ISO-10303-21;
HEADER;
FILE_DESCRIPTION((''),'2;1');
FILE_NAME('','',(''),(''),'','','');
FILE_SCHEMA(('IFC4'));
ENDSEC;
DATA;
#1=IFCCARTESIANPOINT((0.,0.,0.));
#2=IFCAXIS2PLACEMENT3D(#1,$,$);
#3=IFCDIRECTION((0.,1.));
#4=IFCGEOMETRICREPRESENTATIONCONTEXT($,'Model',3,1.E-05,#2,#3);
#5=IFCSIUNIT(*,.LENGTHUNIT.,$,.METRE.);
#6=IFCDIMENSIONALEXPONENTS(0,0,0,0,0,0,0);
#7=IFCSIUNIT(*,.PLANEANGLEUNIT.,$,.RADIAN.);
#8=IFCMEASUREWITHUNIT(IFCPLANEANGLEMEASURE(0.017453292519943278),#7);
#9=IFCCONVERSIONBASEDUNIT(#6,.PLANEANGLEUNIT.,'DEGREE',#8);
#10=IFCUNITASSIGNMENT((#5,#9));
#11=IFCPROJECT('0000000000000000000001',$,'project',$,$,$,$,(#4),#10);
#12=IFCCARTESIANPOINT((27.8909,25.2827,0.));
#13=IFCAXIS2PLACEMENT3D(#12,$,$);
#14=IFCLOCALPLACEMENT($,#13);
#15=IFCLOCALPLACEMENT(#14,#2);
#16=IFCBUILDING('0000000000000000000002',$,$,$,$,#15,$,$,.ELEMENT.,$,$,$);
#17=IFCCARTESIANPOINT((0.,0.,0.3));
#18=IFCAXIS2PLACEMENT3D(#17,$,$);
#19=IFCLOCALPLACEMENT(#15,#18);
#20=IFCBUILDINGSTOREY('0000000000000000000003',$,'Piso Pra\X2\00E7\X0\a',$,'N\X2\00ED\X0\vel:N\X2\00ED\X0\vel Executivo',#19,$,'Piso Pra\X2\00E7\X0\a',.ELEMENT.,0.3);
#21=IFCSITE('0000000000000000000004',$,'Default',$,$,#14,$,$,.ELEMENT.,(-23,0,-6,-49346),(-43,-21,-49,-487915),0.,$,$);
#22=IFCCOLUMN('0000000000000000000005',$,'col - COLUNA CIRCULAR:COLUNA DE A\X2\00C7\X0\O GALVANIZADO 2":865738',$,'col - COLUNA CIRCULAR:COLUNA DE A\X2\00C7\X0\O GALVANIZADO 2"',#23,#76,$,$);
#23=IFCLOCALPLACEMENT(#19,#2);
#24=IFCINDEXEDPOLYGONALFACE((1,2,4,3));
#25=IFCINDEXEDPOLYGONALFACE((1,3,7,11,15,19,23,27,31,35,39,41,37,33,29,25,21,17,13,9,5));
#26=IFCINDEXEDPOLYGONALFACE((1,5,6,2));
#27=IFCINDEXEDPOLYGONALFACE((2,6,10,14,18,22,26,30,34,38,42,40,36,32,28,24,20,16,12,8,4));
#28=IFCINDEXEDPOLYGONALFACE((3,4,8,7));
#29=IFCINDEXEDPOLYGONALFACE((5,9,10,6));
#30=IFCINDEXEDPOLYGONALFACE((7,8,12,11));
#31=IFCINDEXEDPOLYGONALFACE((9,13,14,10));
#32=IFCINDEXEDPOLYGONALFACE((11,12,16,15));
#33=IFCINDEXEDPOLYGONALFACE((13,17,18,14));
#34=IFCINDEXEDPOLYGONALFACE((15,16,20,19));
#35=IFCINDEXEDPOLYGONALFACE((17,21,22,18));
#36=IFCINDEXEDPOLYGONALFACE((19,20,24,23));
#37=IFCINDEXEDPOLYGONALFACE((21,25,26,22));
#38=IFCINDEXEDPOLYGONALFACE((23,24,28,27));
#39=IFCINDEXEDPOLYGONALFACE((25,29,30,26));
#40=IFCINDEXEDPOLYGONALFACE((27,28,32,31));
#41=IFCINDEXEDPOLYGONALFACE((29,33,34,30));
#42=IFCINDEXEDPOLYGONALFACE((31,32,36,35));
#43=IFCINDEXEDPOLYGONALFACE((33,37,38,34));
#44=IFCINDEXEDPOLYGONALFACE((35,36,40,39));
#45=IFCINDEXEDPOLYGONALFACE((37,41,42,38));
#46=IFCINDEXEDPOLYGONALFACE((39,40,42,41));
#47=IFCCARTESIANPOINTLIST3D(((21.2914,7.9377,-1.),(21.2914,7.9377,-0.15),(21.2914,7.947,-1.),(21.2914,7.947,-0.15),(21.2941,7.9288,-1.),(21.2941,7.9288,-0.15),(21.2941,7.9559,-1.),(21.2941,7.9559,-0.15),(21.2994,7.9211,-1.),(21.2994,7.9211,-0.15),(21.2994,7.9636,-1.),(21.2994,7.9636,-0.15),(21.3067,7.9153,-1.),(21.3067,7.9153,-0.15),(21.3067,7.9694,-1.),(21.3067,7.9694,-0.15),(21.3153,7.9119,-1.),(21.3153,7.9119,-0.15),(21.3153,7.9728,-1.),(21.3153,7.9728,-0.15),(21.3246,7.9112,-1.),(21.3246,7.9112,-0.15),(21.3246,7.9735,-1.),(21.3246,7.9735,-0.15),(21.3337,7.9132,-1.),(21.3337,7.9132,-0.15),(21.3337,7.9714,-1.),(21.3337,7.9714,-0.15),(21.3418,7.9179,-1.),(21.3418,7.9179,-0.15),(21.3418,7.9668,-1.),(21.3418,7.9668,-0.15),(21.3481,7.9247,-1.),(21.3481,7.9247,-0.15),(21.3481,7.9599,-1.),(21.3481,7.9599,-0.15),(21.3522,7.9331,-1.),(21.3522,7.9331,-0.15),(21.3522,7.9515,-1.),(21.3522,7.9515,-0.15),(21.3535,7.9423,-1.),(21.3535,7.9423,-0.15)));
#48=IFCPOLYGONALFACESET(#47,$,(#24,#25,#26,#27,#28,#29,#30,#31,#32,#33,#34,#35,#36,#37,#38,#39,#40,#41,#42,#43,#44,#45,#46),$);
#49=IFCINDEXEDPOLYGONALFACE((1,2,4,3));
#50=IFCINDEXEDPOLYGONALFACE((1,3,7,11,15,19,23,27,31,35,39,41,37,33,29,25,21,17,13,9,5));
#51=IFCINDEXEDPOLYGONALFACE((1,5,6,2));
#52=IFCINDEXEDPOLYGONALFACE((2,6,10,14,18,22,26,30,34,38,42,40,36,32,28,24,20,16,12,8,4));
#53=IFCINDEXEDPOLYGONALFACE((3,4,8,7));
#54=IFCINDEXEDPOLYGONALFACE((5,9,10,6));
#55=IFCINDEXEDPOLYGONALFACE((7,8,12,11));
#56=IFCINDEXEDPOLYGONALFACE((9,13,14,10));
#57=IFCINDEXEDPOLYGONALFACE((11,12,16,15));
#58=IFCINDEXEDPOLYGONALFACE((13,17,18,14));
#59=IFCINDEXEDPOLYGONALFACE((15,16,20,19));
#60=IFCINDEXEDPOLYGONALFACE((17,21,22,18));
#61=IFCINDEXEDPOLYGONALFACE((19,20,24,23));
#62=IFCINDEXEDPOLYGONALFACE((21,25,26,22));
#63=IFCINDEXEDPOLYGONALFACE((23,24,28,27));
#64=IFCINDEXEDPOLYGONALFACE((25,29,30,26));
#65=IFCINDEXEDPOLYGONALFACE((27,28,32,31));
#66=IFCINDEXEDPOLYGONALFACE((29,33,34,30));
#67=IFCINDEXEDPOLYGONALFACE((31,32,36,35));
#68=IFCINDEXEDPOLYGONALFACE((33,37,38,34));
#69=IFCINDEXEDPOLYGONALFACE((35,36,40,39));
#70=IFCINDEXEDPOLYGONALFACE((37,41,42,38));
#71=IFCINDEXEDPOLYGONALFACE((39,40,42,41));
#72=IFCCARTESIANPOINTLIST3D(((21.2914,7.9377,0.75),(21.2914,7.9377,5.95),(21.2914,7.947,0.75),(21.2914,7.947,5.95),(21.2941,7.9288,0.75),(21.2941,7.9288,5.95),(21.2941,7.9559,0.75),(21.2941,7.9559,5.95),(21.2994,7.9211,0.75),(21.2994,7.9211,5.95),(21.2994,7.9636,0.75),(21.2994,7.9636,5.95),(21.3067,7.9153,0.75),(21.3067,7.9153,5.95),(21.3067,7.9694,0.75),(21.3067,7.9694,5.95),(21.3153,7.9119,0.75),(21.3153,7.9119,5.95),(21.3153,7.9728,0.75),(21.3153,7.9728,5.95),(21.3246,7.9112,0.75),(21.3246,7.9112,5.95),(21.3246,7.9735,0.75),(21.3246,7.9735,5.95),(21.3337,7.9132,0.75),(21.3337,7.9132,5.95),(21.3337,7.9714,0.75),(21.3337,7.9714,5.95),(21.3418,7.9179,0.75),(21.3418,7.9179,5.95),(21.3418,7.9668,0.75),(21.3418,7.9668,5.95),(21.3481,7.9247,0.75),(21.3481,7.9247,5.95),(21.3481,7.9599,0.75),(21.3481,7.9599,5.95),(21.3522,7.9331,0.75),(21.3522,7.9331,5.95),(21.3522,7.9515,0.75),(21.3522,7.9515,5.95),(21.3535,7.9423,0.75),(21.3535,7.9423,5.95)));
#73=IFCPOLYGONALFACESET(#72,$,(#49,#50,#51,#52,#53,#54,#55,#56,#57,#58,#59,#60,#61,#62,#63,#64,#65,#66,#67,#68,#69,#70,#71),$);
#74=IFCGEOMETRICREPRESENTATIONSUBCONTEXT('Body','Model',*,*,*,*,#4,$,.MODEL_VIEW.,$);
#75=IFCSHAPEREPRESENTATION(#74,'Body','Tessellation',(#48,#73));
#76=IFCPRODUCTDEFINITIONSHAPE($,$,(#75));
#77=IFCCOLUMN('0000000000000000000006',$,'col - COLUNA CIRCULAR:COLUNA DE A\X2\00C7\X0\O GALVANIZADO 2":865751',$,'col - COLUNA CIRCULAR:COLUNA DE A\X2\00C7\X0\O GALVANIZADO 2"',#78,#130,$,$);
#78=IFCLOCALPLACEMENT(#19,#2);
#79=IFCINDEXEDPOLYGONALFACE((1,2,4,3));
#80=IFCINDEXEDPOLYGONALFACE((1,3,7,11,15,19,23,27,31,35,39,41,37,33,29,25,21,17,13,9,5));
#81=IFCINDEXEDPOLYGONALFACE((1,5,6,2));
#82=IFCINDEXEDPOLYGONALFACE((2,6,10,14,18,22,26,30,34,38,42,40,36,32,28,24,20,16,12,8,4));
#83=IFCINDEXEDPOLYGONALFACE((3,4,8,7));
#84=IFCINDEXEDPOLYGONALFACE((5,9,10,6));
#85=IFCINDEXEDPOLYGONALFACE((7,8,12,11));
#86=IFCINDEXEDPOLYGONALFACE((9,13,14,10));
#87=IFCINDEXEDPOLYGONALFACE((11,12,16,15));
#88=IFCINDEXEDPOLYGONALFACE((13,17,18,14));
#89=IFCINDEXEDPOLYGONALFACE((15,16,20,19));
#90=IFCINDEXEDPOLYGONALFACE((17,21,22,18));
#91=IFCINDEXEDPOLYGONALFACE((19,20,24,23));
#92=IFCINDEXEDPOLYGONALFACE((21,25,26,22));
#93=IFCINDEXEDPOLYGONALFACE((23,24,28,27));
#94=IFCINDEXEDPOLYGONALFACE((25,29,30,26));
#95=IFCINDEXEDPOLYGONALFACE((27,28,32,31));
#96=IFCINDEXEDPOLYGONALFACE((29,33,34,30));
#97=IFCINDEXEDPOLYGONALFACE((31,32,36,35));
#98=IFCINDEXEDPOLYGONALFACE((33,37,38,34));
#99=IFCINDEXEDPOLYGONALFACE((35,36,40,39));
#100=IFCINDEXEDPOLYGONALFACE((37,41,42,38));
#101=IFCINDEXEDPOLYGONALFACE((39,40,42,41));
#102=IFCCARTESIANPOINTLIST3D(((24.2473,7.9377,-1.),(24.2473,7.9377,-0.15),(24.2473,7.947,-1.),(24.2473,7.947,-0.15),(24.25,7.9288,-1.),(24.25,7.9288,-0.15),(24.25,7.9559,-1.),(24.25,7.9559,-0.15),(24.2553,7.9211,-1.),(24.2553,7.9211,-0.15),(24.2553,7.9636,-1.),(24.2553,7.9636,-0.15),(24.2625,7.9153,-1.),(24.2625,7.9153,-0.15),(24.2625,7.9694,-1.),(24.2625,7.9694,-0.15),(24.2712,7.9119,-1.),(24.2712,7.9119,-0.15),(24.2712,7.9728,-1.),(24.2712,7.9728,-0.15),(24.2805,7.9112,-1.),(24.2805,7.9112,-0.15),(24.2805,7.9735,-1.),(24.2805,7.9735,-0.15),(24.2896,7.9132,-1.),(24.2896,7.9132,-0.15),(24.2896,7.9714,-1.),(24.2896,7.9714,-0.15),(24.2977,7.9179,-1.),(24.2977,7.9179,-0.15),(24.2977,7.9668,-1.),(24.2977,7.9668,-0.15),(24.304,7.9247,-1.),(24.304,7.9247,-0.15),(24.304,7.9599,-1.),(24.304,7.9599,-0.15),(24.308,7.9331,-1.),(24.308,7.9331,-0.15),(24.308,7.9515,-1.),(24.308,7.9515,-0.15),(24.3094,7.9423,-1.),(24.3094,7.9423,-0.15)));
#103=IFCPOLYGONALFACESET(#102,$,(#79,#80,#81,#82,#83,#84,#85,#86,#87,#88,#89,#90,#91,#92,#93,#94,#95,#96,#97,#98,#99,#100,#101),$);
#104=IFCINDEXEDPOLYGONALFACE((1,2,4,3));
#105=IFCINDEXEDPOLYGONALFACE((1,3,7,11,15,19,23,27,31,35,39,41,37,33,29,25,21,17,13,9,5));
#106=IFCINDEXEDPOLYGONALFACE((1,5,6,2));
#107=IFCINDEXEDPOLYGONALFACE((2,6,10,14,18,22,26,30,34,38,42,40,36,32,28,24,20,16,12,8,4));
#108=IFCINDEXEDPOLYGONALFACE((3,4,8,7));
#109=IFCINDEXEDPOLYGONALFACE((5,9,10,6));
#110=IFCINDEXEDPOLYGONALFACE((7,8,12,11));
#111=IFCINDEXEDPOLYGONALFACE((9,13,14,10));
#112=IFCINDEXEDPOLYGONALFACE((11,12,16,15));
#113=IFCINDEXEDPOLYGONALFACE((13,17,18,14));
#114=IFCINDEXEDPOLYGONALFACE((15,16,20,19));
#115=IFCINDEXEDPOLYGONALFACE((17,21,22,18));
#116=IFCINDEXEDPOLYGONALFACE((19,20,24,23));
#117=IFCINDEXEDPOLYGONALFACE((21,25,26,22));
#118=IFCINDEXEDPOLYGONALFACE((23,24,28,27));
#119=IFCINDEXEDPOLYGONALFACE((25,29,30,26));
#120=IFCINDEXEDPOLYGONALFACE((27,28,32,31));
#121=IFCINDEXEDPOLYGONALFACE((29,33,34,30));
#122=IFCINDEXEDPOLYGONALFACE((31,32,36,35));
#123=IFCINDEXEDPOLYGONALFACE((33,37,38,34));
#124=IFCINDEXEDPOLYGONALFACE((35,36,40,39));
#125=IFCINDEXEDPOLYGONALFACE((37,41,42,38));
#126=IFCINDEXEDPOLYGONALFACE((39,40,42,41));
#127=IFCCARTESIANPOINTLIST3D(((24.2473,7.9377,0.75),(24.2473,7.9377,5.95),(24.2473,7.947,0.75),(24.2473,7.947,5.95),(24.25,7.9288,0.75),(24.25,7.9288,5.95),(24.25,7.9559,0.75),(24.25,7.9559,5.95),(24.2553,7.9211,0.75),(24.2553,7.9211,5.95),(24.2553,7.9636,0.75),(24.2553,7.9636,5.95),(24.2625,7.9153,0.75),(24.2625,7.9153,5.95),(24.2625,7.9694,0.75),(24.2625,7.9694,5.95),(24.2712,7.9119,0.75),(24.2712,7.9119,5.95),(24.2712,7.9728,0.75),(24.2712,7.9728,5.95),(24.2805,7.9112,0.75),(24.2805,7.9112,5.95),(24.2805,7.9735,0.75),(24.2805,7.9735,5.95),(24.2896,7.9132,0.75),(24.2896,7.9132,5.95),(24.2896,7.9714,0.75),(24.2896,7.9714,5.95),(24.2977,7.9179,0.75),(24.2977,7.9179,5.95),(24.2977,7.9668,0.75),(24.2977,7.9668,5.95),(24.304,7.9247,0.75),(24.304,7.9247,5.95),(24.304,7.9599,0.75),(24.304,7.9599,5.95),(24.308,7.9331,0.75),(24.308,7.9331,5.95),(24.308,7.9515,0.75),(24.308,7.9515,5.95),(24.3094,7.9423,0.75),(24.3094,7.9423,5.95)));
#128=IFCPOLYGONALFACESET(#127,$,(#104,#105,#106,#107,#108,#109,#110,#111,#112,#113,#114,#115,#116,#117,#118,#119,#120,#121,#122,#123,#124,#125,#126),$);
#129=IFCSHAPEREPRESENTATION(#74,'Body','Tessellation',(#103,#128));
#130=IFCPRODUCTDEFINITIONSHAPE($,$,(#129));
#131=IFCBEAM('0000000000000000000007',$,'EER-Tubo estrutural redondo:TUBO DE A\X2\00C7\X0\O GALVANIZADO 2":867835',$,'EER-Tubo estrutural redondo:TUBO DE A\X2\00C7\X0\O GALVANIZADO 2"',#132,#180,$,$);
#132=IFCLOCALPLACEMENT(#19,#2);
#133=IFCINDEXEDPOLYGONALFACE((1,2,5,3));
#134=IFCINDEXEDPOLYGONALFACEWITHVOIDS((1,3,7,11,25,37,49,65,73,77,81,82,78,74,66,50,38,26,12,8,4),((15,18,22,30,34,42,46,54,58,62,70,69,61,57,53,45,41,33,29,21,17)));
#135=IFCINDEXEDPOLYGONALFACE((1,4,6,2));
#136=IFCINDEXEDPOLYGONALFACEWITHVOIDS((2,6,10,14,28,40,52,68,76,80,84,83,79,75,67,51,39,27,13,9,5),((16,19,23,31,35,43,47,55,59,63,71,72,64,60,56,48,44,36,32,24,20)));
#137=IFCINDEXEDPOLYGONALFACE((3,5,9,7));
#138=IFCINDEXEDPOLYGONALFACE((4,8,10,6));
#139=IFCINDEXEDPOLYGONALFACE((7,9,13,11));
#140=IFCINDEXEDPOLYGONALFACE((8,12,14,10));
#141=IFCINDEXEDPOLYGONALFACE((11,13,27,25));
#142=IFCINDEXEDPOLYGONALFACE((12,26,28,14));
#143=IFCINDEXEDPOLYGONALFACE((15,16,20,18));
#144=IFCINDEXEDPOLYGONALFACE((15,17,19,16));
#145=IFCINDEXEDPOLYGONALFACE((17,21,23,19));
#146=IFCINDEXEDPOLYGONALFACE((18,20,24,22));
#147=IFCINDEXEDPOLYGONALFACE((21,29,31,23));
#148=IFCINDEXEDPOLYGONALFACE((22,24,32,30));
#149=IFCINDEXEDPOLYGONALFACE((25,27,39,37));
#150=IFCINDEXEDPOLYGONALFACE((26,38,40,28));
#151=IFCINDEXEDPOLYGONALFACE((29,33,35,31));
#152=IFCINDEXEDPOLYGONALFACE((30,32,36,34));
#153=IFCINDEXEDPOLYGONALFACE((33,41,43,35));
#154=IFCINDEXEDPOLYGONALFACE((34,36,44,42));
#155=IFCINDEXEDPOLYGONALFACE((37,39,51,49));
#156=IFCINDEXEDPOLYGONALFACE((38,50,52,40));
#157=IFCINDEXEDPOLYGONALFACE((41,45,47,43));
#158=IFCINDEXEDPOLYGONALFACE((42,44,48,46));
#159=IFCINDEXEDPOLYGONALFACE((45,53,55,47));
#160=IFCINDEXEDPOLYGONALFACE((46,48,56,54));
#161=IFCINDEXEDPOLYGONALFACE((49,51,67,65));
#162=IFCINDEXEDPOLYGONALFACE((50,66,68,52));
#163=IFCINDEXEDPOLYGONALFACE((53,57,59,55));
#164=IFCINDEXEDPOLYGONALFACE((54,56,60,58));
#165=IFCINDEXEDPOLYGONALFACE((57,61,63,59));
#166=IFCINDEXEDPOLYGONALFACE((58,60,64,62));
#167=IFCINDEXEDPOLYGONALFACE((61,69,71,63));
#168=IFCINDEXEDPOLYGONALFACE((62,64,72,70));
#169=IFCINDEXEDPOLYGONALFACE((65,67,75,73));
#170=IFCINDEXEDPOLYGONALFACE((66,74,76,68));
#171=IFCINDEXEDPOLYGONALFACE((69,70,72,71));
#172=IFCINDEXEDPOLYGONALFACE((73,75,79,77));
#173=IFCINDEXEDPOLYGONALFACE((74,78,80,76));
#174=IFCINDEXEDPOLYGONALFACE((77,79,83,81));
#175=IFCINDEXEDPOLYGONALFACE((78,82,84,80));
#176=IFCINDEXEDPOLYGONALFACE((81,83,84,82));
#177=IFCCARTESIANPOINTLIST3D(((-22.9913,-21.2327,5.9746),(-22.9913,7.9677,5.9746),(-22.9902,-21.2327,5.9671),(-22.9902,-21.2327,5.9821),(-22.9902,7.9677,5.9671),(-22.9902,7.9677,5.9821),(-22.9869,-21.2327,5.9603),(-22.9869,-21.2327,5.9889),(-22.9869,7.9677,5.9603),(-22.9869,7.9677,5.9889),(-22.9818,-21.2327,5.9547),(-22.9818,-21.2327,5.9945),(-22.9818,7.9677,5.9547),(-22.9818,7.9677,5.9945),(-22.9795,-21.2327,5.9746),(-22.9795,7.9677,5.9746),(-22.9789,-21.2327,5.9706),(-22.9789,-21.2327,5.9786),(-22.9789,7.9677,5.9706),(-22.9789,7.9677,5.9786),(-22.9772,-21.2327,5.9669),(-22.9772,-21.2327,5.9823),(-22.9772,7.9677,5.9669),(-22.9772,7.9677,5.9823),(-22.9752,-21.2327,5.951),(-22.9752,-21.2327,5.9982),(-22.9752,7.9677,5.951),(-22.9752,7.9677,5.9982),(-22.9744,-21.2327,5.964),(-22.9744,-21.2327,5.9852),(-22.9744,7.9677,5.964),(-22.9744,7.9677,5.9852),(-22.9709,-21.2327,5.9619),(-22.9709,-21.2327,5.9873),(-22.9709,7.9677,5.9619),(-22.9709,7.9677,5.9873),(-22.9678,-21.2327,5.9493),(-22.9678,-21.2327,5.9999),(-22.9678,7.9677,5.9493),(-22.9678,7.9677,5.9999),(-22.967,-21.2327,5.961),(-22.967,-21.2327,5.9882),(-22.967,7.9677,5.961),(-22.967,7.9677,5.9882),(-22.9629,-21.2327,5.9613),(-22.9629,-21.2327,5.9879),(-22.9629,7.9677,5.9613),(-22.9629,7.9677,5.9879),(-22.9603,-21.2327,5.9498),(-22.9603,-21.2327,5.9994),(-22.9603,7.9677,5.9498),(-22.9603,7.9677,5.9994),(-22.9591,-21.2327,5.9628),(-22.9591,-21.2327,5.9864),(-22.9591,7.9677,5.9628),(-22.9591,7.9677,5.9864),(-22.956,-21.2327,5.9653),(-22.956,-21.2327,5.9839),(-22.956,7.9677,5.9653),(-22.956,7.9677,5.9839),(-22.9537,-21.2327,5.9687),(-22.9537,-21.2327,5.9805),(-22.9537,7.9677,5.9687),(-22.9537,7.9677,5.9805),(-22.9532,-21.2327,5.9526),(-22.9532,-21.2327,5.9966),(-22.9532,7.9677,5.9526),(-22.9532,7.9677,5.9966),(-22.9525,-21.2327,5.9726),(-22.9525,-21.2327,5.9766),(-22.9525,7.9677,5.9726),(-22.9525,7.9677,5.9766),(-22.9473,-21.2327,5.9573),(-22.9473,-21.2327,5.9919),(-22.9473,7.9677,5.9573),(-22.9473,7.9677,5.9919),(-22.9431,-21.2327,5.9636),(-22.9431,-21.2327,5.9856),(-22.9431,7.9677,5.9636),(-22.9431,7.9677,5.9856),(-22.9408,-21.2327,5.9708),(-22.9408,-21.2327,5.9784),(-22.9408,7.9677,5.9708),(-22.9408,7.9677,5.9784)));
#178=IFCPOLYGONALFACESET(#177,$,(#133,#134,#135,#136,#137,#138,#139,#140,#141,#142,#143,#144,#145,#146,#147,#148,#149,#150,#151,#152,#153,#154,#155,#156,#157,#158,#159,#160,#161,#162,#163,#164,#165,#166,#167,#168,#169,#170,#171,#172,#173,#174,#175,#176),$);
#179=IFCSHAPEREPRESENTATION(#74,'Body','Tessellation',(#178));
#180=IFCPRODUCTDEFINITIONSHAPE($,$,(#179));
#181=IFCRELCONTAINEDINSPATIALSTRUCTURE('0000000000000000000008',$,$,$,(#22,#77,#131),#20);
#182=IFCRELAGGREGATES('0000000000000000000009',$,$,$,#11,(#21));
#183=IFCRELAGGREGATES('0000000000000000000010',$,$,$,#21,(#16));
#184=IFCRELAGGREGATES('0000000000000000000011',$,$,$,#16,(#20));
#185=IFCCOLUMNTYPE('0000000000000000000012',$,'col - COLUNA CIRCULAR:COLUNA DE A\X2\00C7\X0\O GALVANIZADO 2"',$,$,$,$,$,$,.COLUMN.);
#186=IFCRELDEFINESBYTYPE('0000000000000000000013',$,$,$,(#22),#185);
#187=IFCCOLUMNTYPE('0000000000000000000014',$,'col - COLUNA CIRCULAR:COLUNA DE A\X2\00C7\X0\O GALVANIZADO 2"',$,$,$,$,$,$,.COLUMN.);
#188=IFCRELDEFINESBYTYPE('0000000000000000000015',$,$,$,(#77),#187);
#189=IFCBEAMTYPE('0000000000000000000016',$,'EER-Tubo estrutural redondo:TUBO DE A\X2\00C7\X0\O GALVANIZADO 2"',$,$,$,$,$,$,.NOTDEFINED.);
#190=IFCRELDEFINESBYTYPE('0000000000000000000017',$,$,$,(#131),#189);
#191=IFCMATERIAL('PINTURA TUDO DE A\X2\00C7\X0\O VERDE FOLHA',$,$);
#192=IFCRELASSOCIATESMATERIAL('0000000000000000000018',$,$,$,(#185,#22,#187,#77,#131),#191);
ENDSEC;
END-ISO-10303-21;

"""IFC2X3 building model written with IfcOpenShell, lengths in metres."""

from ifc_helpers import new_model, entity, si_unit, converted_unit, direction, frame, origin, origin_2d_with_axis, place, context, subcontext, project, spatial, circle, hollow_circle, extrude, source, transform, mapped, material, type_object, type_shapes, element, save


model = new_model("IFC2X3")

# Units and contexts
model_context = context("Model", 3, precision=1e-05, world=origin(), true_north=direction((0.0, 1.0)))
body_context = subcontext(model_context, "Body", "Model", "MODEL_VIEW")
ifc_project = project(units=[si_unit("LENGTHUNIT", "METRE"), converted_unit("PLANEANGLEUNIT", "DEGREE", entity("IfcPlaneAngleMeasure", 0.017453292519943278), si_unit("PLANEANGLEUNIT", "RADIAN"), dimensions=[0, 0, 0, 0, 0, 0, 0])], contexts=[model_context])

# Site, building, storey
site_placement = place(None, frame((27.8909, 25.2827, 0.0)))
site = spatial("IfcSite", under=ifc_project, at=site_placement, Name="Default", CompositionType="ELEMENT", RefLatitude=(-23, 0, -6, -49346), RefLongitude=(-43, -21, -49, -487915), RefElevation=0.0)
building_placement = place(site_placement, origin())
building = spatial("IfcBuilding", under=site, at=building_placement, CompositionType="ELEMENT")
storey_placement = place(building_placement, frame((0.0, 0.0, 0.3)))
storey = spatial("IfcBuildingStorey", under=building, at=storey_placement, Name="Piso Praça", ObjectType="Nível:Nível Executivo", LongName="Piso Praça", CompositionType="ELEMENT", Elevation=0.3)

# Columns
ifc_material_1 = material(Name="PINTURA TUDO DE AÇO VERDE FOLHA")
column_type_1 = type_object("IfcColumnType", Name="col - COLUNA CIRCULAR:COLUNA DE AÇO GALVANIZADO 2\"", PredefinedType="COLUMN", material=ifc_material_1)
shared_shape_1 = source(origin(), body_context, "Body", "SweptSolid", [
    extrude(circle(Radius=0.0312, at=origin_2d_with_axis()), frame((21.3223, 7.9423, -0.7)), (0.0, 0.0, 1.0), 0.85),
    extrude(circle(Radius=0.0312, at=origin_2d_with_axis()), frame((21.3223, 7.9423, 1.05)), (0.0, 0.0, 1.0), 5.2),
])
type_shapes(column_type_1, [shared_shape_1])
column_1_placement = place(storey_placement, frame((0.0, 0.0, -0.3)))
element("IfcColumn", 1, at=column_1_placement, inside=storey, type_object=column_type_1, material=ifc_material_1, Name="col - COLUNA CIRCULAR:COLUNA DE AÇO GALVANIZADO 2\":865738", ObjectType="col - COLUNA CIRCULAR:COLUNA DE AÇO GALVANIZADO 2\"", context=body_context, shape_type="MappedRepresentation", body=[
    mapped(shared_shape_1, transform((0.0, 0.0, 0.0), scale=1.0)),
])
column_type_2 = type_object("IfcColumnType", Name="col - COLUNA CIRCULAR:COLUNA DE AÇO GALVANIZADO 2\"", PredefinedType="COLUMN", material=ifc_material_1)
shared_shape_2 = source(origin(), body_context, "Body", "SweptSolid", [
    extrude(circle(Radius=0.0312, at=origin_2d_with_axis()), frame((24.2782, 7.9423, -0.7)), (0.0, 0.0, 1.0), 0.85),
    extrude(circle(Radius=0.0312, at=origin_2d_with_axis()), frame((24.2782, 7.9423, 1.05)), (0.0, 0.0, 1.0), 5.2),
])
type_shapes(column_type_2, [shared_shape_2])
column_2_placement = place(storey_placement, frame((0.0, 0.0, -0.3)))
element("IfcColumn", 2, at=column_2_placement, inside=storey, type_object=column_type_2, material=ifc_material_1, Name="col - COLUNA CIRCULAR:COLUNA DE AÇO GALVANIZADO 2\":865751", ObjectType="col - COLUNA CIRCULAR:COLUNA DE AÇO GALVANIZADO 2\"", context=body_context, shape_type="MappedRepresentation", body=[
    mapped(shared_shape_2, transform((0.0, 0.0, 0.0), scale=1.0)),
])

# Beam
beam_type_1 = type_object("IfcBeamType", Name="EER-Tubo estrutural redondo:TUBO DE AÇO GALVANIZADO 2\"", PredefinedType="NOTDEFINED")
beam_1_placement = place(storey_placement, frame((-22.9659, -21.2073, 6.0), z_axis=(0.0, 0.0, 1.0), x_axis=(0.0, 1.0, 0.0)))
element("IfcBeam", 3, at=beam_1_placement, inside=storey, type_object=beam_type_1, material=ifc_material_1, Name="EER-Tubo estrutural redondo:TUBO DE AÇO GALVANIZADO 2\":867835", ObjectType="EER-Tubo estrutural redondo:TUBO DE AÇO GALVANIZADO 2\"", context=body_context, shape_type="SweptSolid", body=[
    extrude(hollow_circle(Radius=0.0254, WallThickness=0.0118, at=origin_2d_with_axis()), frame((-0.0254, 0.0, -0.0254), z_axis=(1.0, 0.0, 0.0), x_axis=(0.0, 1.0, 0.0)), (0.0, 0.0, 1.0), 29.2004),
])

save(model, "model.ifc")
